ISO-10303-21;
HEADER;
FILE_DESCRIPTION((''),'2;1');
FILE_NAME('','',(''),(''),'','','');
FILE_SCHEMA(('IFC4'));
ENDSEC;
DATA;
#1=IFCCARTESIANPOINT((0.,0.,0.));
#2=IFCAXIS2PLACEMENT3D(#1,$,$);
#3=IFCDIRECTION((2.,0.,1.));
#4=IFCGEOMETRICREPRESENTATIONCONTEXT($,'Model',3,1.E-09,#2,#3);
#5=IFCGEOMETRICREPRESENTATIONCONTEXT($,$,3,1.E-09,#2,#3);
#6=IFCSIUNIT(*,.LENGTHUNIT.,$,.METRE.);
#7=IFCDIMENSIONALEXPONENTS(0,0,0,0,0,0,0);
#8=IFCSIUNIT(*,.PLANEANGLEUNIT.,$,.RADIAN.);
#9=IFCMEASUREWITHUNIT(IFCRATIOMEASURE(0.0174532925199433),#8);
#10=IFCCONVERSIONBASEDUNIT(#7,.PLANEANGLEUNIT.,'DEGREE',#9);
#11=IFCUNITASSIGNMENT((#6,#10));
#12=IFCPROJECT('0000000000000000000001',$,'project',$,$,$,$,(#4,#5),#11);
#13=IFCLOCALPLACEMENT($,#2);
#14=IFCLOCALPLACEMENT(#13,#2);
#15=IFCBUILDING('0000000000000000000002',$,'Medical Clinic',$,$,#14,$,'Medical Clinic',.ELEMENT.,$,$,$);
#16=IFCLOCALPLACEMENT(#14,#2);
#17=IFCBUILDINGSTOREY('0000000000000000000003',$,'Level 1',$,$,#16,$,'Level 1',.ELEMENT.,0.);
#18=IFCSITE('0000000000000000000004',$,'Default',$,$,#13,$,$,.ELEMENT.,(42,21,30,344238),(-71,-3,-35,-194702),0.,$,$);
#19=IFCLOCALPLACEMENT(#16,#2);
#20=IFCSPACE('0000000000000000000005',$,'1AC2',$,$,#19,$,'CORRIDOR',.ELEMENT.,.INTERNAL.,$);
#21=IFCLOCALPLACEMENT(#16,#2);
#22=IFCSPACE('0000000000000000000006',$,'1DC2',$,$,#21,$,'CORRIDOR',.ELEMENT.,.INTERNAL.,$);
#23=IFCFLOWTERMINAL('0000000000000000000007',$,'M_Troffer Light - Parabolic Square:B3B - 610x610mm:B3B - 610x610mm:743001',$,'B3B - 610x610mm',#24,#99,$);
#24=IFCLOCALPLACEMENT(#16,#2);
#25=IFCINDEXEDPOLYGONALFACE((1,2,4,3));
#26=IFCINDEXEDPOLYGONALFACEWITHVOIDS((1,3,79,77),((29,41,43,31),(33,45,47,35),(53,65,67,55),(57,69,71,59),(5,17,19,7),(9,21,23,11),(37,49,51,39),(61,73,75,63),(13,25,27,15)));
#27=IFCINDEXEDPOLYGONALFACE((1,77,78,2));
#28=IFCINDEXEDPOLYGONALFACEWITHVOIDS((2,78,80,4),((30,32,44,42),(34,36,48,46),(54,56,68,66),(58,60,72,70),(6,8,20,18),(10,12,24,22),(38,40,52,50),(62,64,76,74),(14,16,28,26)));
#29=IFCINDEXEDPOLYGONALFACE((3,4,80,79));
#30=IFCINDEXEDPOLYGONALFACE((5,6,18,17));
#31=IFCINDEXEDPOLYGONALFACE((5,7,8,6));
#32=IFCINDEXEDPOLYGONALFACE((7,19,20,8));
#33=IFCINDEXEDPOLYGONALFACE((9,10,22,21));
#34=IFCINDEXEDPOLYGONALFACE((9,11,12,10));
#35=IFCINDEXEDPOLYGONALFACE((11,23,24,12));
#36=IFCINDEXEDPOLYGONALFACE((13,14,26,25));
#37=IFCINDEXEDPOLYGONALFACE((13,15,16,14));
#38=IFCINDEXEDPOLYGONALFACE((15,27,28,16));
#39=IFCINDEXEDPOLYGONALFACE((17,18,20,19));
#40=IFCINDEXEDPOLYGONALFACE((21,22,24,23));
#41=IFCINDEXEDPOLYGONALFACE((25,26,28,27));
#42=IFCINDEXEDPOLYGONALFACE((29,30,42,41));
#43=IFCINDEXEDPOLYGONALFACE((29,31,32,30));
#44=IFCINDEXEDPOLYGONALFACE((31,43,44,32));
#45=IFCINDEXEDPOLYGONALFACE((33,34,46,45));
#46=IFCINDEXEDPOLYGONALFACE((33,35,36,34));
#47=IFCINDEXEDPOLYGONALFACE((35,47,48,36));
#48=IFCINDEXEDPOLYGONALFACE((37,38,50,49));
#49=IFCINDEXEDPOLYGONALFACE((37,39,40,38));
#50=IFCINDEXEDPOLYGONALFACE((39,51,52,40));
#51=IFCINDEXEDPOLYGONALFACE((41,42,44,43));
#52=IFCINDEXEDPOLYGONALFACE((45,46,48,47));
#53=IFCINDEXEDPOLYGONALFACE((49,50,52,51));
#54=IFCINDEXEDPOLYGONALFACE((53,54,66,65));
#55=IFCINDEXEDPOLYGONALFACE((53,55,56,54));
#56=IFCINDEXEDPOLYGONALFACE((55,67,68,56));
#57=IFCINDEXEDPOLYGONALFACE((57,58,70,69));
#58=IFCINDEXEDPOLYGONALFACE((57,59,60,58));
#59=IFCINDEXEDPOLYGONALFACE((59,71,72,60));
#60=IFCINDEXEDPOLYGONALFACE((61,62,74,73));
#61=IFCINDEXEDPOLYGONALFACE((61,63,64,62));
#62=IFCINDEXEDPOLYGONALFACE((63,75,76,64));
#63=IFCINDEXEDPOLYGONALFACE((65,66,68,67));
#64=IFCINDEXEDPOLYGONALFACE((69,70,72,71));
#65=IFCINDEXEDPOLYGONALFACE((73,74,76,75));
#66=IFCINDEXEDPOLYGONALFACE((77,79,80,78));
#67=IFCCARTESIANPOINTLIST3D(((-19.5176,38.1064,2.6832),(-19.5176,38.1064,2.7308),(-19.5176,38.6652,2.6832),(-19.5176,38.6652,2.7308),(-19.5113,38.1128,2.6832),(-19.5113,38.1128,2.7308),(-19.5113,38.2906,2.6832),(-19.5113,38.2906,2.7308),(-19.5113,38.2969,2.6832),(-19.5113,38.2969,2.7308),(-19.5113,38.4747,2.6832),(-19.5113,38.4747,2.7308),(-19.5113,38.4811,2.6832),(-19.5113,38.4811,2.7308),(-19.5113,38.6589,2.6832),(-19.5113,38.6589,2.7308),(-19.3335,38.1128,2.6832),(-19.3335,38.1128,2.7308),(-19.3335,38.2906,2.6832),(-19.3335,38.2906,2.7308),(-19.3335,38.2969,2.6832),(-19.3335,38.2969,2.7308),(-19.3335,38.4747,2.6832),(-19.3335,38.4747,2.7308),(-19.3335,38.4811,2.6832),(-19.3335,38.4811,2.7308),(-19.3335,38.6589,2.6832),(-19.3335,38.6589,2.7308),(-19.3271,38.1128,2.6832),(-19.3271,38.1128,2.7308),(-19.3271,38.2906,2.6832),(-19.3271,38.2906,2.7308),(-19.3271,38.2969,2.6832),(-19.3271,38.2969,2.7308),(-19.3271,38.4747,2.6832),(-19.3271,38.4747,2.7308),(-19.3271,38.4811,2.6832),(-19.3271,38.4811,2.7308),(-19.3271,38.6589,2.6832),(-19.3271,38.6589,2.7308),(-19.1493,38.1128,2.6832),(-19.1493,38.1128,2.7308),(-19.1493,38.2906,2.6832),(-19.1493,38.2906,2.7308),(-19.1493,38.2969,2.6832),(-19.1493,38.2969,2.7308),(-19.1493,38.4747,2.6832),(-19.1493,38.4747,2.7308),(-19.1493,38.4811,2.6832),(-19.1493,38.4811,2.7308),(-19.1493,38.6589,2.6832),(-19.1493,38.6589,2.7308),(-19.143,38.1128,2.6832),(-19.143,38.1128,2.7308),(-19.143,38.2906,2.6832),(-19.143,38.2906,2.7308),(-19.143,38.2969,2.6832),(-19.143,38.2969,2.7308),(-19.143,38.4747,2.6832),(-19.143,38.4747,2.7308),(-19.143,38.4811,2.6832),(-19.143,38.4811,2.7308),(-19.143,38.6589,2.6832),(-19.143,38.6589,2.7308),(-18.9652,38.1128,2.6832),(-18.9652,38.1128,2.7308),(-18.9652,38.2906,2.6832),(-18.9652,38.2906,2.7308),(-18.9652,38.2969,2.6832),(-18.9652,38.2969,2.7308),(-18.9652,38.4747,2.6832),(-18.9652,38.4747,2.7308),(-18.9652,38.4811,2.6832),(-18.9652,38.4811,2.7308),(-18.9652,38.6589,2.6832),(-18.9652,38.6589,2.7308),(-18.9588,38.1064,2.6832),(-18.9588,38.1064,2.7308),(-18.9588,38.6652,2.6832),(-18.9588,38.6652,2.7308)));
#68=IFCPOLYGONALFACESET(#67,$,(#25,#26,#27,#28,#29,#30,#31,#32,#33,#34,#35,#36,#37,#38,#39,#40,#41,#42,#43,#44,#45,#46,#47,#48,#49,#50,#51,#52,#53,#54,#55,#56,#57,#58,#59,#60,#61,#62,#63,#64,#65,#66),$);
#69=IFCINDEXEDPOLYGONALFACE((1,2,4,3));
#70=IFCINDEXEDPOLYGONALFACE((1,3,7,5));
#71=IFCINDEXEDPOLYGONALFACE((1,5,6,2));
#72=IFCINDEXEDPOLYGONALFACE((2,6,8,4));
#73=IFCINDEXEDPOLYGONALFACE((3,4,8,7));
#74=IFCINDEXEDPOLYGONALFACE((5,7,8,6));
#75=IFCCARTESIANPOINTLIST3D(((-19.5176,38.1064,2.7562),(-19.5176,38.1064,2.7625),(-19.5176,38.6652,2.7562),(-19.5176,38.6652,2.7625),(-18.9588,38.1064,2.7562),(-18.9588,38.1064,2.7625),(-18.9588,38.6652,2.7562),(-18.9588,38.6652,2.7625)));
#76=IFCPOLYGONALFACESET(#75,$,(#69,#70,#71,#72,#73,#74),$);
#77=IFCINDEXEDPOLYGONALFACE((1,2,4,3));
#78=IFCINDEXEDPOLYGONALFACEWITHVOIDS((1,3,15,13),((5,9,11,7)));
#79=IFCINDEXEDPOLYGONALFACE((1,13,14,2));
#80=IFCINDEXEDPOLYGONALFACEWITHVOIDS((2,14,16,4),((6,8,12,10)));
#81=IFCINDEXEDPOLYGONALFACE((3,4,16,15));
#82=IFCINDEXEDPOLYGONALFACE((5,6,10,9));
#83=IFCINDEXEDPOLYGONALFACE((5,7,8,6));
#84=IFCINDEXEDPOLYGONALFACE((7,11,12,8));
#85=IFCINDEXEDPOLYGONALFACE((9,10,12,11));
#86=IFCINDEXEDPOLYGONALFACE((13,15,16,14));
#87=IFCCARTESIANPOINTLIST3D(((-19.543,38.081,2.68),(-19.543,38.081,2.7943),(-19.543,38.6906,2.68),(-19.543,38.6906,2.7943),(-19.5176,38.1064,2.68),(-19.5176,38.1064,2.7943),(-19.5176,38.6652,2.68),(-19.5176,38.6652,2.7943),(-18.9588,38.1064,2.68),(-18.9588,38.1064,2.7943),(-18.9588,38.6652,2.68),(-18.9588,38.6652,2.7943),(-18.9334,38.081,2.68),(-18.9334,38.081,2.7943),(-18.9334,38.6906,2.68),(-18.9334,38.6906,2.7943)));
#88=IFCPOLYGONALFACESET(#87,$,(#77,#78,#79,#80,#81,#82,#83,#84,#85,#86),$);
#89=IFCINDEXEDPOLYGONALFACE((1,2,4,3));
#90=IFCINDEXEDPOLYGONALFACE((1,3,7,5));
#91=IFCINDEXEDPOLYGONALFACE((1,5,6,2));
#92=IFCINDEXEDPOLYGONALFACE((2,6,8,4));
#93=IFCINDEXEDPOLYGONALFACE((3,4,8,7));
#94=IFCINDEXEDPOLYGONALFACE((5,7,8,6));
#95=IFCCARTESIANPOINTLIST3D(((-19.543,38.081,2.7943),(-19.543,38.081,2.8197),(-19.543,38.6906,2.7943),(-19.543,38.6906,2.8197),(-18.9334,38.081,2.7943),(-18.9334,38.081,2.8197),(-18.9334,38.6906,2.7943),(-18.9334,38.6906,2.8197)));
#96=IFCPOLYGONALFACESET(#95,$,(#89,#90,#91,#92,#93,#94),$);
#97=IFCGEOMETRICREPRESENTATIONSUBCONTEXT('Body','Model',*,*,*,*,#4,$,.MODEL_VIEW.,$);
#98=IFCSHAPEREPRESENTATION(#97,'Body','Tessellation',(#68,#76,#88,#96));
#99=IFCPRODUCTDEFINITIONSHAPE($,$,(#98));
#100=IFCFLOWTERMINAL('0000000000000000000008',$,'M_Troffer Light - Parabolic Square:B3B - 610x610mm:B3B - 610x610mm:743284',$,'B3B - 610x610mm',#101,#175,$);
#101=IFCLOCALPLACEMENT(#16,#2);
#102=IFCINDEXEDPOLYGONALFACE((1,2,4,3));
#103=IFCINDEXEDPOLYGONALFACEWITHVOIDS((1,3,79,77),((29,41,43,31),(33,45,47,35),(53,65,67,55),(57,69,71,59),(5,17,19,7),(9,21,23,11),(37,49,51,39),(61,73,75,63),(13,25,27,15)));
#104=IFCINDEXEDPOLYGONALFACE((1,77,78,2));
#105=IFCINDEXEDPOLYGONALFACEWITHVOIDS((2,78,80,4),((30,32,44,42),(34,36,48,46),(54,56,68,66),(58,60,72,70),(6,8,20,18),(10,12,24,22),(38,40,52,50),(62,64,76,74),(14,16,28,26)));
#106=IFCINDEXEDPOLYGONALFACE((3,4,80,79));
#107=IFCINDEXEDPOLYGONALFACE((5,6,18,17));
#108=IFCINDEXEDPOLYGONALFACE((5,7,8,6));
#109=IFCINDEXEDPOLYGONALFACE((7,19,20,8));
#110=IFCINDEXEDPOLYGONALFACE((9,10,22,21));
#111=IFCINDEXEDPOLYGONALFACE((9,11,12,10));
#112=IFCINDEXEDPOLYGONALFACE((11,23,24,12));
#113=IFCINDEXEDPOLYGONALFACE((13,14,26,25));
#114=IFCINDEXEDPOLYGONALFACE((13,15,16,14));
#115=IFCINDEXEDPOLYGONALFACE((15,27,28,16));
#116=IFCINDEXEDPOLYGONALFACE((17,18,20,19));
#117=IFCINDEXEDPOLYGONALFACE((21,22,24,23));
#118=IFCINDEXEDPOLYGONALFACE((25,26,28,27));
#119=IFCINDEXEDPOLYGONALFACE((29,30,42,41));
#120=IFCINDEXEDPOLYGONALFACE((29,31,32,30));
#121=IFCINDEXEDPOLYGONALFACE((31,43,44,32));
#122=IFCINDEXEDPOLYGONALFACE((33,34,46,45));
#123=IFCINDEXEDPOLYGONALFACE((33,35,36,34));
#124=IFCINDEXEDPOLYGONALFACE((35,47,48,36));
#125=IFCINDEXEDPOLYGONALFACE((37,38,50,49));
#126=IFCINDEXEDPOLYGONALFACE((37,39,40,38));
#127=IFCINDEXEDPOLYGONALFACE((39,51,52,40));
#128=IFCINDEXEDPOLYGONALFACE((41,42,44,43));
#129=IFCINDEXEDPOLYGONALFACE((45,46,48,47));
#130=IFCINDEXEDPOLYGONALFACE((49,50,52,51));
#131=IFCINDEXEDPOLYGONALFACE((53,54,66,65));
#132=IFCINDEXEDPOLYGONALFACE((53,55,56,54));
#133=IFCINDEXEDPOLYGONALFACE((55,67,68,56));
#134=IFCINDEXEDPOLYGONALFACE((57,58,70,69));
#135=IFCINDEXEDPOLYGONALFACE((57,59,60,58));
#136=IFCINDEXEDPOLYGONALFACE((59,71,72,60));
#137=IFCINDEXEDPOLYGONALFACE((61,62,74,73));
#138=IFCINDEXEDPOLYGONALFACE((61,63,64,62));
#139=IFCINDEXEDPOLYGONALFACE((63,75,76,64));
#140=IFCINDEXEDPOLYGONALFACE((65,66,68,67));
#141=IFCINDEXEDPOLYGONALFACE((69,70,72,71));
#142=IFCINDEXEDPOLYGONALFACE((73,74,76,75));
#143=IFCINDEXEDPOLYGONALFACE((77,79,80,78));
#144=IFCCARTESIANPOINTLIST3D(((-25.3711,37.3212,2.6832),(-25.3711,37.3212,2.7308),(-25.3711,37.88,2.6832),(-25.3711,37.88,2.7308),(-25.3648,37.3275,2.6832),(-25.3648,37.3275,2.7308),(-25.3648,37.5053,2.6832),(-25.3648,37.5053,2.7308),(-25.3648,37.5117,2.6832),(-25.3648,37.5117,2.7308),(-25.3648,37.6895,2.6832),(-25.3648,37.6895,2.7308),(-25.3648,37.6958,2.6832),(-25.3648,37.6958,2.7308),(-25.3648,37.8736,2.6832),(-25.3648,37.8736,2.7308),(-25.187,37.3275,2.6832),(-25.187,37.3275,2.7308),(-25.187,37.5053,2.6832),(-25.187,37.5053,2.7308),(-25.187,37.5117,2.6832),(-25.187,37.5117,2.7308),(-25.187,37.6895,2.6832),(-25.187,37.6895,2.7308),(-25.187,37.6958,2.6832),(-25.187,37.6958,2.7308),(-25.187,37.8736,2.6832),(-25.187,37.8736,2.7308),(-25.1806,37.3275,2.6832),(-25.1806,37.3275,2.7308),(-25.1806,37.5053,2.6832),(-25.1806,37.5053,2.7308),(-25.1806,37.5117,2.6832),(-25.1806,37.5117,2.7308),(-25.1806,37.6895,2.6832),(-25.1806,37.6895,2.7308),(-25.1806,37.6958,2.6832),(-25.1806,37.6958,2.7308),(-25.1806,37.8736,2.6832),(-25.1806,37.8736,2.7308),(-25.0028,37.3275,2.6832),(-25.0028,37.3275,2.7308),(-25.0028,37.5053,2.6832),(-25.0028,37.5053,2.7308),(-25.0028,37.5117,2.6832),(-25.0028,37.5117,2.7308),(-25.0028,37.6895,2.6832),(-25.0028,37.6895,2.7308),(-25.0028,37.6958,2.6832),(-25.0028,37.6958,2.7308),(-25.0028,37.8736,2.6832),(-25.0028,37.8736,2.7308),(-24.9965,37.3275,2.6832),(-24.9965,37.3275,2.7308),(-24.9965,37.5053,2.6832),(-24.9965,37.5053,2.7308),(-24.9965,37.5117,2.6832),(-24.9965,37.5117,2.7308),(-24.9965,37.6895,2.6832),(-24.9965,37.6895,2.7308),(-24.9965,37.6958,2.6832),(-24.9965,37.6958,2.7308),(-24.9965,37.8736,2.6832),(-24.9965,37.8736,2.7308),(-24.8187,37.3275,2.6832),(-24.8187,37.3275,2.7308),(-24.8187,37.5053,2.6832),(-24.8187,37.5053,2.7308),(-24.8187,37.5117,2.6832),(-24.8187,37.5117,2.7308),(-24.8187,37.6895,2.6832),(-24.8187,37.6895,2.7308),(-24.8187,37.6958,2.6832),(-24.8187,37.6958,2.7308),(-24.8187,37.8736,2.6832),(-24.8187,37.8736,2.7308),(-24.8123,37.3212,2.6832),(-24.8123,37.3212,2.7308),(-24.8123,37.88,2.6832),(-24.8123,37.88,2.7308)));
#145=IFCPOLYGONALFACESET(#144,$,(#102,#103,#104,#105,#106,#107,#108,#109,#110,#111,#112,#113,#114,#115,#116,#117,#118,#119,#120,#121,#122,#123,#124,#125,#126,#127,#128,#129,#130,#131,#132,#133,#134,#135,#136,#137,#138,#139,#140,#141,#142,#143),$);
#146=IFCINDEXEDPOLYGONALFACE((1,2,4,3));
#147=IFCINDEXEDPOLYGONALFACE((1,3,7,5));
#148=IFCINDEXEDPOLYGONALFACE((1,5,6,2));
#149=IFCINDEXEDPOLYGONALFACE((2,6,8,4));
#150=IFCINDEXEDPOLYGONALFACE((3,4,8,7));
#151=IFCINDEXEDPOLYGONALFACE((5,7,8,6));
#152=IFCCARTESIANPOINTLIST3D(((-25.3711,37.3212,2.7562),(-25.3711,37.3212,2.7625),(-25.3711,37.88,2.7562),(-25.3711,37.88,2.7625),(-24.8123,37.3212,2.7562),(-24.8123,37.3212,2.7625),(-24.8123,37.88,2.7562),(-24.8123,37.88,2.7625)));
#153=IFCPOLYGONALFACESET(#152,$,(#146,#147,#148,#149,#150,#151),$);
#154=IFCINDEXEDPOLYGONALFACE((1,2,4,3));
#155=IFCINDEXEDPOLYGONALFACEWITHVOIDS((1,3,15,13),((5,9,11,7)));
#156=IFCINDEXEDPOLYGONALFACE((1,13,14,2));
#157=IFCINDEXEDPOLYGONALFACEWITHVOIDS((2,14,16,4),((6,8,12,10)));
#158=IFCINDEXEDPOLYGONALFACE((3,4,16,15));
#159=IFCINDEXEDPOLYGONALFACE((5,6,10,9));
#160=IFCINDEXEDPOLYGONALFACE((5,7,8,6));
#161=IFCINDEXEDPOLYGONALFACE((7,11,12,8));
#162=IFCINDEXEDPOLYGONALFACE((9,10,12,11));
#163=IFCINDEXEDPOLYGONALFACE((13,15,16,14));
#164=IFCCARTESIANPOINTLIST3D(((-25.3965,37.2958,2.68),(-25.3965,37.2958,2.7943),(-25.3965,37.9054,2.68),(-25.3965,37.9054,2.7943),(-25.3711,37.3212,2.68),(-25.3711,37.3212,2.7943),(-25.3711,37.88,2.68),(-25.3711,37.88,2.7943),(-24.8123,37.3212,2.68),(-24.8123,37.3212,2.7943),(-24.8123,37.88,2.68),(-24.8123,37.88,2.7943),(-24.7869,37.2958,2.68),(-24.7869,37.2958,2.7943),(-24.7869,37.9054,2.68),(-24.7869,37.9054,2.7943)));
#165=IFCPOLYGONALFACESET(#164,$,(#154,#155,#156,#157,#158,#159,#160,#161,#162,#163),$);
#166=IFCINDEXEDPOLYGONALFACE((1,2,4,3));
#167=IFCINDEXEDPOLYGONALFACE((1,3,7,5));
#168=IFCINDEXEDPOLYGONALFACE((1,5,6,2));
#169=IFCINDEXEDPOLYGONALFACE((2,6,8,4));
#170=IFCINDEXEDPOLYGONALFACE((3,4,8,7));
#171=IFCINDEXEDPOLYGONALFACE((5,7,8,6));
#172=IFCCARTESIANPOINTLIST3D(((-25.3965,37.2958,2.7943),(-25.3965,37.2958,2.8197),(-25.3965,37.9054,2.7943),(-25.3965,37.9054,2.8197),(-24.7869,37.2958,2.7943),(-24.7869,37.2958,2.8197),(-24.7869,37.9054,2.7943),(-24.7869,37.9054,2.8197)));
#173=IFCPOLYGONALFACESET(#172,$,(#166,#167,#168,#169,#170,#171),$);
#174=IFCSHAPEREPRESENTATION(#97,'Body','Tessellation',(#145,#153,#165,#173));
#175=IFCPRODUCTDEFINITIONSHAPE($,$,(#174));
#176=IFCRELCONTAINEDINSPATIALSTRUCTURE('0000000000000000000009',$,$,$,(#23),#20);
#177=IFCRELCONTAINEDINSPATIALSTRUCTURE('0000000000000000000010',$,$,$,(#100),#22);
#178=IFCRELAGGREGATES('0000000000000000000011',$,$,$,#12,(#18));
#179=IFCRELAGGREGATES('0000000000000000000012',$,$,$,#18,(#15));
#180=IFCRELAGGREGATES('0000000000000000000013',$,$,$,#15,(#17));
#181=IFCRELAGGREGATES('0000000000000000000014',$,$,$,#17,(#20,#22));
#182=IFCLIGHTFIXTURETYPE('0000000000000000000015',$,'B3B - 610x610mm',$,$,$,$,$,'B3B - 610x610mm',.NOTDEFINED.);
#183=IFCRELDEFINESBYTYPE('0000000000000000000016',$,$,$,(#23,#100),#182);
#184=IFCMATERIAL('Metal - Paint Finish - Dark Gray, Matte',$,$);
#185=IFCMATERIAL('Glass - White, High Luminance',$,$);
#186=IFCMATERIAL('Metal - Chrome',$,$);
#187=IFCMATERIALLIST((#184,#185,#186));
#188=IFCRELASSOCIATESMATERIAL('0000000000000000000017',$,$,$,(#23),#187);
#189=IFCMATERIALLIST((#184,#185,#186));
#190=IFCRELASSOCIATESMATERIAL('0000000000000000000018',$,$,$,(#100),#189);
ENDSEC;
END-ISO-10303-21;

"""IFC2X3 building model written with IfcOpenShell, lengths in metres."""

from ifc_helpers import new_model, entity, si_unit, converted_unit, direction, frame, origin, origin_2d_with_axis, place, context, subcontext, project, spatial, polyline, rectangle, outline, extrude, source, transform, mapped, material, material_list, type_object, type_shapes, element, save


model = new_model("IFC2X3")

# Units and contexts
model_context = context("Model", 3, precision=1e-09, world=origin(), true_north=direction((2.0, 0.0, 1.0)))
context_of_model = context(None, 3, precision=1e-09, world=origin(), true_north=direction((2.0, 0.0, 1.0)))
body_context = subcontext(model_context, "Body", "Model", "MODEL_VIEW")
ifc_project = project(units=[si_unit("LENGTHUNIT", "METRE"), converted_unit("PLANEANGLEUNIT", "DEGREE", entity("IfcRatioMeasure", 0.0174532925199433), si_unit("PLANEANGLEUNIT", "RADIAN"), dimensions=[0, 0, 0, 0, 0, 0, 0])], contexts=[model_context, context_of_model])

# Site, building, storey
site_placement = place(None, origin())
site = spatial("IfcSite", under=ifc_project, at=site_placement, Name="Default", CompositionType="ELEMENT", RefLatitude=(42, 21, 30, 344238), RefLongitude=(-71, -3, -35, -194702), RefElevation=0.0)
building_placement = place(site_placement, origin())
building = spatial("IfcBuilding", under=site, at=building_placement, Name="Medical Clinic", LongName="Medical Clinic", CompositionType="ELEMENT")
storey_placement = place(building_placement, origin())
storey = spatial("IfcBuildingStorey", under=building, at=storey_placement, Name="Level 1", LongName="Level 1", CompositionType="ELEMENT", Elevation=0.0)

# Shared definitions
ifc_material_1 = material(Name="Metal - Paint Finish - Dark Gray, Matte")
ifc_material_2 = material(Name="Glass - White, High Luminance")
ifc_material_3 = material(Name="Metal - Chrome")

# Shared definitions
space_1_placement = place(storey_placement, origin())
space_1 = spatial("IfcSpace", under=storey, at=space_1_placement, Name="1AC2", LongName="CORRIDOR", CompositionType="ELEMENT", InteriorOrExteriorSpace="INTERNAL")

# Flow terminal
ifc_material_list_1 = material_list([ifc_material_1, ifc_material_2, ifc_material_3])
light_fixture_type_1 = type_object("IfcLightFixtureType", Name="B3B - 610x610mm", ElementType="B3B - 610x610mm", PredefinedType="NOTDEFINED")
shared_shape_1 = source(origin(), body_context, "Body", "SweptSolid", [
    extrude(outline(polyline([(-0.2794, -0.2794), (0.2794, -0.2794), (0.2794, 0.2794), (-0.2794, 0.2794), (-0.2794, -0.2794)]), holes=[polyline([(-0.0952, 0.0953), (-0.273, 0.0953), (-0.273, 0.2731), (-0.0952, 0.2731), (-0.0952, 0.0953)]), polyline([(0.2731, 0.0953), (0.0953, 0.0953), (0.0953, 0.2731), (0.2731, 0.2731), (0.2731, 0.0953)]), polyline([(-0.0889, 0.2731), (0.0889, 0.2731), (0.0889, 0.0953), (-0.0889, 0.0953), (-0.0889, 0.2731)]), polyline([(0.2731, -0.273), (0.0953, -0.273), (0.0953, -0.0952), (0.2731, -0.0952), (0.2731, -0.273)]), polyline([(0.0889, -0.273), (-0.0889, -0.273), (-0.0889, -0.0952), (0.0889, -0.0952), (0.0889, -0.273)]), polyline([(-0.0952, -0.273), (-0.273, -0.273), (-0.273, -0.0952), (-0.0952, -0.0952), (-0.0952, -0.273)]), polyline([(-0.0952, -0.0889), (-0.273, -0.0889), (-0.273, 0.0889), (-0.0952, 0.0889), (-0.0952, -0.0889)]), polyline([(0.0889, -0.0889), (-0.0889, -0.0889), (-0.0889, 0.0889), (0.0889, 0.0889), (0.0889, -0.0889)]), polyline([(0.2731, -0.0889), (0.0953, -0.0889), (0.0953, 0.0889), (0.2731, 0.0889), (0.2731, -0.0889)])]), frame((0.0, -0.3048, -0.0508), z_axis=(0.0, 0.0, 1.0), x_axis=(-1.0, 0.0, 0.0)), (0.0, 0.0, 1.0), 0.0476),
    extrude(rectangle(XDim=0.5588, YDim=0.5588, at=origin_2d_with_axis()), frame((0.0, -0.3048, -0.0825), z_axis=(0.0, 0.0, 1.0), x_axis=(-1.0, 0.0, 0.0)), (0.0, 0.0, 1.0), 0.0064),
    extrude(outline(polyline([(-0.3048, -0.3048), (0.3048, -0.3048), (0.3048, 0.3048), (-0.3048, 0.3048), (-0.3048, -0.3048)]), holes=[polyline([(0.2794, 0.2794), (0.2794, -0.2794), (-0.2794, -0.2794), (-0.2794, 0.2794), (0.2794, 0.2794)])]), frame((0.0, -0.3048, -0.1143)), (0.0, 0.0, 1.0), 0.1143),
    extrude(rectangle(XDim=0.6096, YDim=0.6096, at=origin_2d_with_axis()), frame((0.0, -0.3048, -0.1397), z_axis=(0.0, 0.0, 1.0), x_axis=(-1.0, 0.0, 0.0)), (0.0, 0.0, 1.0), 0.0254),
])
type_shapes(light_fixture_type_1, [shared_shape_1])
flow_terminal_1_placement = place(space_1_placement, frame((-19.2382, 38.081, 2.68), z_axis=(0.0, 0.0, -1.0), x_axis=(1.0, 0.0, 0.0)))
element("IfcFlowTerminal", 1, at=flow_terminal_1_placement, inside=space_1, type_object=light_fixture_type_1, material=ifc_material_list_1, Name="M_Troffer Light - Parabolic Square:B3B - 610x610mm:B3B - 610x610mm:743001", ObjectType="B3B - 610x610mm", context=body_context, shape_type="MappedRepresentation", body=[
    mapped(shared_shape_1, transform((0.0, 0.0, 0.0), scale=1.0)),
])

# Shared definitions
space_2_placement = place(storey_placement, origin())
space_2 = spatial("IfcSpace", under=storey, at=space_2_placement, Name="1DC2", LongName="CORRIDOR", CompositionType="ELEMENT", InteriorOrExteriorSpace="INTERNAL")

# Flow terminal
ifc_material_list_2 = material_list([ifc_material_1, ifc_material_2, ifc_material_3])
flow_terminal_2_placement = place(space_2_placement, frame((-25.0917, 37.2958, 2.68), z_axis=(0.0, 0.0, -1.0), x_axis=(1.0, 0.0, 0.0)))
element("IfcFlowTerminal", 2, at=flow_terminal_2_placement, inside=space_2, type_object=light_fixture_type_1, material=ifc_material_list_2, Name="M_Troffer Light - Parabolic Square:B3B - 610x610mm:B3B - 610x610mm:743284", ObjectType="B3B - 610x610mm", context=body_context, shape_type="MappedRepresentation", body=[
    mapped(shared_shape_1, transform((0.0, 0.0, 0.0), scale=1.0)),
])

save(model, "model.ifc")
